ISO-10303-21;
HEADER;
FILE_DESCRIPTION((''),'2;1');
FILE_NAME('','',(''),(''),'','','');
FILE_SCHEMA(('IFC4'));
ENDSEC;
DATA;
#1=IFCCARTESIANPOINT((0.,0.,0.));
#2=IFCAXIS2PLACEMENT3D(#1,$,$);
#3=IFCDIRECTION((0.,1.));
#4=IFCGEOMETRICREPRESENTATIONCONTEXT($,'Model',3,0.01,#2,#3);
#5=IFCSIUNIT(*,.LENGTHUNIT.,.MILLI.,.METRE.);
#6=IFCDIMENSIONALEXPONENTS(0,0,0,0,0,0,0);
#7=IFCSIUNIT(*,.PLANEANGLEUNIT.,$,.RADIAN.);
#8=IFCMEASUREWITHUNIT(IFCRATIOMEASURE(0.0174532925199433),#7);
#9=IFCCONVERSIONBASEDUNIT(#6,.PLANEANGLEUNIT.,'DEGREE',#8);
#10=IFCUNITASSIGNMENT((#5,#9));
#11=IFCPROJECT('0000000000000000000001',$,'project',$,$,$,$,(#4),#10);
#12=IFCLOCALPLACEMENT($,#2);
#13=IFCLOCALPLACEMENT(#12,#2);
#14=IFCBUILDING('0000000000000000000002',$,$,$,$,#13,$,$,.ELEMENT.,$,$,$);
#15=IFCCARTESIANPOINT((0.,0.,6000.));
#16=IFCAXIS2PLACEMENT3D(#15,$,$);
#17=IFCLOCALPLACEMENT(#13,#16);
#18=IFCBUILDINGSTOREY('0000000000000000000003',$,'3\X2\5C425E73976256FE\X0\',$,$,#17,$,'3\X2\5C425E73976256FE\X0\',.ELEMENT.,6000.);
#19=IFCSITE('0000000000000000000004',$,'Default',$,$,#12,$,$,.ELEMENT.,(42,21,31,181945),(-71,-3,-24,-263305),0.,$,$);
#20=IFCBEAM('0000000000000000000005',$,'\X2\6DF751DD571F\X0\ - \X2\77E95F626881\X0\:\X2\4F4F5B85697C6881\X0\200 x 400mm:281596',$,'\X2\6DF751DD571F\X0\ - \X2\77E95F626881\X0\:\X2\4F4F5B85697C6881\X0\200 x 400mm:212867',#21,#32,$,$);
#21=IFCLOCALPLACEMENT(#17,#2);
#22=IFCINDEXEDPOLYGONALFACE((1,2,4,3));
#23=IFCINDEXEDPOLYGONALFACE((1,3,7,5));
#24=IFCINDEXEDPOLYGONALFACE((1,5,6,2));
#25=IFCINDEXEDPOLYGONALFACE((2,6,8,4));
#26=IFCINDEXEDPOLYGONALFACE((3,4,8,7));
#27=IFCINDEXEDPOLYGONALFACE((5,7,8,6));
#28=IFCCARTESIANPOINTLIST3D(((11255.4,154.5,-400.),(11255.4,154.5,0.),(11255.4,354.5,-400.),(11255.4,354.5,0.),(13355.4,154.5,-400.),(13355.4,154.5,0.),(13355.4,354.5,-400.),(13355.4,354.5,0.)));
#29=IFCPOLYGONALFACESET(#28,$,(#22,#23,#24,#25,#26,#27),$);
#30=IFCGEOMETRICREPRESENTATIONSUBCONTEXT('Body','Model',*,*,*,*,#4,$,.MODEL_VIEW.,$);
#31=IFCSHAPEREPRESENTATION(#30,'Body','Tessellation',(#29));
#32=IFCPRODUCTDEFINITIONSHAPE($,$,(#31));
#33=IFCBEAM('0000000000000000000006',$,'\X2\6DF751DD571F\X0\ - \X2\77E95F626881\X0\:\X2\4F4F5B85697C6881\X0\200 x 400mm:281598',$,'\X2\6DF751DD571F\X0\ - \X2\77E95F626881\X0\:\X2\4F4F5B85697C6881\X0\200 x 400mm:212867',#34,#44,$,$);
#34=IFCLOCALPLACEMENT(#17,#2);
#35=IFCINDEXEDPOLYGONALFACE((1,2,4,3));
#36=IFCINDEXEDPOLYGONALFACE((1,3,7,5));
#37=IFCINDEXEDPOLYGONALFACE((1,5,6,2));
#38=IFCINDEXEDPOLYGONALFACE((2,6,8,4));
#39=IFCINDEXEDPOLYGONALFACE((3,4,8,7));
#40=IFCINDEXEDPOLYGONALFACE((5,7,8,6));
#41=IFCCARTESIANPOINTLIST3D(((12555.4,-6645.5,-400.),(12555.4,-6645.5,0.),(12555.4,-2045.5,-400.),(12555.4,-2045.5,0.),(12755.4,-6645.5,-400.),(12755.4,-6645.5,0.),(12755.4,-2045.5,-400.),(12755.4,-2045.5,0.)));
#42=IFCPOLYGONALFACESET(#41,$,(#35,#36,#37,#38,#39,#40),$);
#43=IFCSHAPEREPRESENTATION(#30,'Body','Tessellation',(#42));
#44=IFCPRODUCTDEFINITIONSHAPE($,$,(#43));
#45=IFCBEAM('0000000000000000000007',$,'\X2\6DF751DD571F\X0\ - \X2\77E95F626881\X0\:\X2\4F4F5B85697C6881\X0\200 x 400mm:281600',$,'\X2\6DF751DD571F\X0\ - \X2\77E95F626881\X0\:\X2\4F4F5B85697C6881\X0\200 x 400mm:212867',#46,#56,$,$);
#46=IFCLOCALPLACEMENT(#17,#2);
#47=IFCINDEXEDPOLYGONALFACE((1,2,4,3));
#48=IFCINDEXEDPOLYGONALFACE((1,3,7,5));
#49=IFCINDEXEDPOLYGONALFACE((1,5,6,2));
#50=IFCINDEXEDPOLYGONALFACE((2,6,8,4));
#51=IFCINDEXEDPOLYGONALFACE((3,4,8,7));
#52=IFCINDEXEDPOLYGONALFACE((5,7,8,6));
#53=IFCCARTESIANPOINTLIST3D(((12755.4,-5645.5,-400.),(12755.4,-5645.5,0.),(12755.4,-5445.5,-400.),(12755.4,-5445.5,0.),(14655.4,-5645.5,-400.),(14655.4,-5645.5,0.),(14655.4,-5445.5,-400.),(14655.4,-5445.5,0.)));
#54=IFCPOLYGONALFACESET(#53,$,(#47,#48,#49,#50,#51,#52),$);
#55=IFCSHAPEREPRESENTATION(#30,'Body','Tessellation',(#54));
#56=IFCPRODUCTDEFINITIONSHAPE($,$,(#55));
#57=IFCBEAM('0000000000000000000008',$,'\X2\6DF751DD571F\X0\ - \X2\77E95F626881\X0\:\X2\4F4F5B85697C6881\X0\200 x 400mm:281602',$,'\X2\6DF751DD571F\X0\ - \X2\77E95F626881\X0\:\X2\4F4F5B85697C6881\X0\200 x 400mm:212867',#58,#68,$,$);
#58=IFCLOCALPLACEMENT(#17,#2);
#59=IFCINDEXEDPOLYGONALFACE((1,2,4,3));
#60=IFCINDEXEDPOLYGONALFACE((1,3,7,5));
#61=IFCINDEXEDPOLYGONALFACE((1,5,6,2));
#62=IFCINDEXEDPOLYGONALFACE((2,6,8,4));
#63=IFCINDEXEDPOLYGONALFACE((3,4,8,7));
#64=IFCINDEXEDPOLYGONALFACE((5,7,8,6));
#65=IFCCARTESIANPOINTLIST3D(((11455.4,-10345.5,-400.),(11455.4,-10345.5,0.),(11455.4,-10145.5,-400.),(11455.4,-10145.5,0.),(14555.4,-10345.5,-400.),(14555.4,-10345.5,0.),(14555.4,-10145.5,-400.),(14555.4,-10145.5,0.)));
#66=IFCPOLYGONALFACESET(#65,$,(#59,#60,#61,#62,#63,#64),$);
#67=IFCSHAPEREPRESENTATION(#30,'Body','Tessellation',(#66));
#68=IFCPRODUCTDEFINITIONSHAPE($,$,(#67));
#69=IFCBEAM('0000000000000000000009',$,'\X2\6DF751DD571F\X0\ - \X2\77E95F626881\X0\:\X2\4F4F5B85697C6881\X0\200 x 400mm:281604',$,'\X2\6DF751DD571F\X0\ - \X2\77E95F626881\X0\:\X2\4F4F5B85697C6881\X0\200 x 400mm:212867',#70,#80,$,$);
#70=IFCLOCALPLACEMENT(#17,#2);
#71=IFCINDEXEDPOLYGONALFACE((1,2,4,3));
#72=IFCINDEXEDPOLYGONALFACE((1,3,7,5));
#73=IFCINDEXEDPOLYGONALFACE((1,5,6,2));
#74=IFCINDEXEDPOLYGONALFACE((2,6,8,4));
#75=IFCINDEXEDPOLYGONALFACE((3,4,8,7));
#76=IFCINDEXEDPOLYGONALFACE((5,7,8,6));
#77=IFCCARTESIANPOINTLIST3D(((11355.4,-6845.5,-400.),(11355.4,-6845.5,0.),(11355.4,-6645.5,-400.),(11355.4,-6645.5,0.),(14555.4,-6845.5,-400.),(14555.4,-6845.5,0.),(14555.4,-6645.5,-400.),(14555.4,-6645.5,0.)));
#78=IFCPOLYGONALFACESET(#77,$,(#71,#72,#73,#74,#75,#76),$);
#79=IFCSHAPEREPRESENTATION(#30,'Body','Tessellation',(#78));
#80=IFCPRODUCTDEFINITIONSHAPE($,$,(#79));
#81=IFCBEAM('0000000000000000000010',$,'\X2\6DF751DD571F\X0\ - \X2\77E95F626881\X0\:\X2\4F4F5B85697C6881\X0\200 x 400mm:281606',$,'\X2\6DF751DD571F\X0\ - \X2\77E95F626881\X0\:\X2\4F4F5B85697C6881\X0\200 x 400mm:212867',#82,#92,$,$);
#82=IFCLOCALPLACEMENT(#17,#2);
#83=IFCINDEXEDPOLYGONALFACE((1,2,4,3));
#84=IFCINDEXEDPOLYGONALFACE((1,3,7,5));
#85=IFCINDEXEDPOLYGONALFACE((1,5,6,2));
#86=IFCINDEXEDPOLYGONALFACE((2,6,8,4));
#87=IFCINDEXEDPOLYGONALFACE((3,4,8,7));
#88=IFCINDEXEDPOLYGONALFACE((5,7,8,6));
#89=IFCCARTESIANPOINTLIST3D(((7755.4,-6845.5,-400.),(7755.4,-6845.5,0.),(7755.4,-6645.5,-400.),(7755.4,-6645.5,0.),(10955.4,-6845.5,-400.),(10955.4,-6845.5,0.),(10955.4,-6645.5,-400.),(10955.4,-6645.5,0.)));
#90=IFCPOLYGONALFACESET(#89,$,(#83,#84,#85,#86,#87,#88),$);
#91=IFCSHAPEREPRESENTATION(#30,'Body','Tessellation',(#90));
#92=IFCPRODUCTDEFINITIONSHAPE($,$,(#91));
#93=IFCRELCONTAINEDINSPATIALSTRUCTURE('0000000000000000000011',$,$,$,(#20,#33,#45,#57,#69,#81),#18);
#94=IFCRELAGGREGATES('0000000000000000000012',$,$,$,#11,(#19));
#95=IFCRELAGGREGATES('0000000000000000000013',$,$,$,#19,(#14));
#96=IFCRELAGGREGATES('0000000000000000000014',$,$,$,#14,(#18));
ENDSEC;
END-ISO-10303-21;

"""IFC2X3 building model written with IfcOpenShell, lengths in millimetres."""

from ifc_helpers import new_model, entity, si_unit, converted_unit, direction, frame, frame_2d, origin, origin_2d_with_axis, place, context, subcontext, project, spatial, rectangle, extrude, element, save


model = new_model("IFC2X3")

# Units and contexts
model_context = context("Model", 3, precision=0.01, world=origin(), true_north=direction((0.0, 1.0)))
body_context = subcontext(model_context, "Body", "Model", "MODEL_VIEW")
ifc_project = project(units=[si_unit("LENGTHUNIT", "METRE", prefix="MILLI"), converted_unit("PLANEANGLEUNIT", "DEGREE", entity("IfcRatioMeasure", 0.0174532925199433), si_unit("PLANEANGLEUNIT", "RADIAN"), dimensions=[0, 0, 0, 0, 0, 0, 0])], contexts=[model_context])

# Site, building, storey
site_placement = place(None, origin())
site = spatial("IfcSite", under=ifc_project, at=site_placement, Name="Default", CompositionType="ELEMENT", RefLatitude=(42, 21, 31, 181945), RefLongitude=(-71, -3, -24, -263305), RefElevation=0.0)
building_placement = place(site_placement, origin())
building = spatial("IfcBuilding", under=site, at=building_placement, CompositionType="ELEMENT")
storey_placement = place(building_placement, frame((0.0, 0.0, 6000.0)))
storey = spatial("IfcBuildingStorey", under=building, at=storey_placement, Name="3层平面图", LongName="3层平面图", CompositionType="ELEMENT", Elevation=6000.0)

# Beams
beam_1_placement = place(storey_placement, frame((11155.4, 254.5, 0.0)))
element("IfcBeam", 1, at=beam_1_placement, inside=storey, Name="混凝土 - 矩形梁:住宅楼梁200 x 400mm:281596", ObjectType="混凝土 - 矩形梁:住宅楼梁200 x 400mm:212867", context=body_context, shape_type="SweptSolid", body=[
    extrude(rectangle(XDim=400.0, YDim=200.0, at=frame_2d((0.0, 0.0), x_axis=(1.0, 0.0))), frame((100.0, 0.0, -200.0), z_axis=(1.0, 0.0, 0.0), x_axis=(0.0, 0.0, -1.0)), (0.0, 0.0, 1.0), 2100.0),
])
beam_2_placement = place(storey_placement, frame((12655.4, -1945.5, 0.0), z_axis=(0.0, 0.0, 1.0), x_axis=(0.0, -1.0, 0.0)))
element("IfcBeam", 2, at=beam_2_placement, inside=storey, Name="混凝土 - 矩形梁:住宅楼梁200 x 400mm:281598", ObjectType="混凝土 - 矩形梁:住宅楼梁200 x 400mm:212867", context=body_context, shape_type="SweptSolid", body=[
    extrude(rectangle(XDim=400.0, YDim=200.0, at=origin_2d_with_axis()), frame((100.0, 0.0, -200.0), z_axis=(1.0, 0.0, 0.0), x_axis=(0.0, 0.0, -1.0)), (0.0, 0.0, 1.0), 4600.0),
])
beam_3_placement = place(storey_placement, frame((12655.4, -5545.5, 0.0)))
element("IfcBeam", 3, at=beam_3_placement, inside=storey, Name="混凝土 - 矩形梁:住宅楼梁200 x 400mm:281600", ObjectType="混凝土 - 矩形梁:住宅楼梁200 x 400mm:212867", context=body_context, shape_type="SweptSolid", body=[
    extrude(rectangle(XDim=400.0, YDim=200.0, at=frame_2d((0.0, 0.0), x_axis=(1.0, 0.0))), frame((100.0, 0.0, -200.0), z_axis=(1.0, 0.0, 0.0), x_axis=(0.0, 0.0, -1.0)), (0.0, 0.0, 1.0), 1900.0),
])
beam_4_placement = place(storey_placement, frame((11455.4, -10245.5, 0.0)))
element("IfcBeam", 4, at=beam_4_placement, inside=storey, Name="混凝土 - 矩形梁:住宅楼梁200 x 400mm:281602", ObjectType="混凝土 - 矩形梁:住宅楼梁200 x 400mm:212867", context=body_context, shape_type="SweptSolid", body=[
    extrude(rectangle(XDim=400.0, YDim=200.0, at=frame_2d((0.0, 0.0), x_axis=(1.0, 0.0))), frame((0.0, 0.0, -200.0), z_axis=(1.0, 0.0, 0.0), x_axis=(0.0, 0.0, -1.0)), (0.0, 0.0, 1.0), 3100.0),
])
beam_5_placement = place(storey_placement, frame((11155.4, -6745.5, 0.0)))
element("IfcBeam", 5, at=beam_5_placement, inside=storey, Name="混凝土 - 矩形梁:住宅楼梁200 x 400mm:281604", ObjectType="混凝土 - 矩形梁:住宅楼梁200 x 400mm:212867", context=body_context, shape_type="SweptSolid", body=[
    extrude(rectangle(XDim=400.0, YDim=200.0, at=frame_2d((0.0, 0.0), x_axis=(1.0, 0.0))), frame((200.0, 0.0, -200.0), z_axis=(1.0, 0.0, 0.0), x_axis=(0.0, 0.0, -1.0)), (0.0, 0.0, 1.0), 3200.0),
])
beam_6_placement = place(storey_placement, frame((11155.4, -6745.5, 0.0), z_axis=(0.0, 0.0, 1.0), x_axis=(-1.0, 0.0, 0.0)))
element("IfcBeam", 6, at=beam_6_placement, inside=storey, Name="混凝土 - 矩形梁:住宅楼梁200 x 400mm:281606", ObjectType="混凝土 - 矩形梁:住宅楼梁200 x 400mm:212867", context=body_context, shape_type="SweptSolid", body=[
    extrude(rectangle(XDim=400.0, YDim=200.0, at=frame_2d((0.0, 0.0), x_axis=(1.0, 0.0))), frame((200.0, 0.0, -200.0), z_axis=(1.0, 0.0, 0.0), x_axis=(0.0, 0.0, -1.0)), (0.0, 0.0, 1.0), 3200.0),
])

save(model, "model.ifc")
